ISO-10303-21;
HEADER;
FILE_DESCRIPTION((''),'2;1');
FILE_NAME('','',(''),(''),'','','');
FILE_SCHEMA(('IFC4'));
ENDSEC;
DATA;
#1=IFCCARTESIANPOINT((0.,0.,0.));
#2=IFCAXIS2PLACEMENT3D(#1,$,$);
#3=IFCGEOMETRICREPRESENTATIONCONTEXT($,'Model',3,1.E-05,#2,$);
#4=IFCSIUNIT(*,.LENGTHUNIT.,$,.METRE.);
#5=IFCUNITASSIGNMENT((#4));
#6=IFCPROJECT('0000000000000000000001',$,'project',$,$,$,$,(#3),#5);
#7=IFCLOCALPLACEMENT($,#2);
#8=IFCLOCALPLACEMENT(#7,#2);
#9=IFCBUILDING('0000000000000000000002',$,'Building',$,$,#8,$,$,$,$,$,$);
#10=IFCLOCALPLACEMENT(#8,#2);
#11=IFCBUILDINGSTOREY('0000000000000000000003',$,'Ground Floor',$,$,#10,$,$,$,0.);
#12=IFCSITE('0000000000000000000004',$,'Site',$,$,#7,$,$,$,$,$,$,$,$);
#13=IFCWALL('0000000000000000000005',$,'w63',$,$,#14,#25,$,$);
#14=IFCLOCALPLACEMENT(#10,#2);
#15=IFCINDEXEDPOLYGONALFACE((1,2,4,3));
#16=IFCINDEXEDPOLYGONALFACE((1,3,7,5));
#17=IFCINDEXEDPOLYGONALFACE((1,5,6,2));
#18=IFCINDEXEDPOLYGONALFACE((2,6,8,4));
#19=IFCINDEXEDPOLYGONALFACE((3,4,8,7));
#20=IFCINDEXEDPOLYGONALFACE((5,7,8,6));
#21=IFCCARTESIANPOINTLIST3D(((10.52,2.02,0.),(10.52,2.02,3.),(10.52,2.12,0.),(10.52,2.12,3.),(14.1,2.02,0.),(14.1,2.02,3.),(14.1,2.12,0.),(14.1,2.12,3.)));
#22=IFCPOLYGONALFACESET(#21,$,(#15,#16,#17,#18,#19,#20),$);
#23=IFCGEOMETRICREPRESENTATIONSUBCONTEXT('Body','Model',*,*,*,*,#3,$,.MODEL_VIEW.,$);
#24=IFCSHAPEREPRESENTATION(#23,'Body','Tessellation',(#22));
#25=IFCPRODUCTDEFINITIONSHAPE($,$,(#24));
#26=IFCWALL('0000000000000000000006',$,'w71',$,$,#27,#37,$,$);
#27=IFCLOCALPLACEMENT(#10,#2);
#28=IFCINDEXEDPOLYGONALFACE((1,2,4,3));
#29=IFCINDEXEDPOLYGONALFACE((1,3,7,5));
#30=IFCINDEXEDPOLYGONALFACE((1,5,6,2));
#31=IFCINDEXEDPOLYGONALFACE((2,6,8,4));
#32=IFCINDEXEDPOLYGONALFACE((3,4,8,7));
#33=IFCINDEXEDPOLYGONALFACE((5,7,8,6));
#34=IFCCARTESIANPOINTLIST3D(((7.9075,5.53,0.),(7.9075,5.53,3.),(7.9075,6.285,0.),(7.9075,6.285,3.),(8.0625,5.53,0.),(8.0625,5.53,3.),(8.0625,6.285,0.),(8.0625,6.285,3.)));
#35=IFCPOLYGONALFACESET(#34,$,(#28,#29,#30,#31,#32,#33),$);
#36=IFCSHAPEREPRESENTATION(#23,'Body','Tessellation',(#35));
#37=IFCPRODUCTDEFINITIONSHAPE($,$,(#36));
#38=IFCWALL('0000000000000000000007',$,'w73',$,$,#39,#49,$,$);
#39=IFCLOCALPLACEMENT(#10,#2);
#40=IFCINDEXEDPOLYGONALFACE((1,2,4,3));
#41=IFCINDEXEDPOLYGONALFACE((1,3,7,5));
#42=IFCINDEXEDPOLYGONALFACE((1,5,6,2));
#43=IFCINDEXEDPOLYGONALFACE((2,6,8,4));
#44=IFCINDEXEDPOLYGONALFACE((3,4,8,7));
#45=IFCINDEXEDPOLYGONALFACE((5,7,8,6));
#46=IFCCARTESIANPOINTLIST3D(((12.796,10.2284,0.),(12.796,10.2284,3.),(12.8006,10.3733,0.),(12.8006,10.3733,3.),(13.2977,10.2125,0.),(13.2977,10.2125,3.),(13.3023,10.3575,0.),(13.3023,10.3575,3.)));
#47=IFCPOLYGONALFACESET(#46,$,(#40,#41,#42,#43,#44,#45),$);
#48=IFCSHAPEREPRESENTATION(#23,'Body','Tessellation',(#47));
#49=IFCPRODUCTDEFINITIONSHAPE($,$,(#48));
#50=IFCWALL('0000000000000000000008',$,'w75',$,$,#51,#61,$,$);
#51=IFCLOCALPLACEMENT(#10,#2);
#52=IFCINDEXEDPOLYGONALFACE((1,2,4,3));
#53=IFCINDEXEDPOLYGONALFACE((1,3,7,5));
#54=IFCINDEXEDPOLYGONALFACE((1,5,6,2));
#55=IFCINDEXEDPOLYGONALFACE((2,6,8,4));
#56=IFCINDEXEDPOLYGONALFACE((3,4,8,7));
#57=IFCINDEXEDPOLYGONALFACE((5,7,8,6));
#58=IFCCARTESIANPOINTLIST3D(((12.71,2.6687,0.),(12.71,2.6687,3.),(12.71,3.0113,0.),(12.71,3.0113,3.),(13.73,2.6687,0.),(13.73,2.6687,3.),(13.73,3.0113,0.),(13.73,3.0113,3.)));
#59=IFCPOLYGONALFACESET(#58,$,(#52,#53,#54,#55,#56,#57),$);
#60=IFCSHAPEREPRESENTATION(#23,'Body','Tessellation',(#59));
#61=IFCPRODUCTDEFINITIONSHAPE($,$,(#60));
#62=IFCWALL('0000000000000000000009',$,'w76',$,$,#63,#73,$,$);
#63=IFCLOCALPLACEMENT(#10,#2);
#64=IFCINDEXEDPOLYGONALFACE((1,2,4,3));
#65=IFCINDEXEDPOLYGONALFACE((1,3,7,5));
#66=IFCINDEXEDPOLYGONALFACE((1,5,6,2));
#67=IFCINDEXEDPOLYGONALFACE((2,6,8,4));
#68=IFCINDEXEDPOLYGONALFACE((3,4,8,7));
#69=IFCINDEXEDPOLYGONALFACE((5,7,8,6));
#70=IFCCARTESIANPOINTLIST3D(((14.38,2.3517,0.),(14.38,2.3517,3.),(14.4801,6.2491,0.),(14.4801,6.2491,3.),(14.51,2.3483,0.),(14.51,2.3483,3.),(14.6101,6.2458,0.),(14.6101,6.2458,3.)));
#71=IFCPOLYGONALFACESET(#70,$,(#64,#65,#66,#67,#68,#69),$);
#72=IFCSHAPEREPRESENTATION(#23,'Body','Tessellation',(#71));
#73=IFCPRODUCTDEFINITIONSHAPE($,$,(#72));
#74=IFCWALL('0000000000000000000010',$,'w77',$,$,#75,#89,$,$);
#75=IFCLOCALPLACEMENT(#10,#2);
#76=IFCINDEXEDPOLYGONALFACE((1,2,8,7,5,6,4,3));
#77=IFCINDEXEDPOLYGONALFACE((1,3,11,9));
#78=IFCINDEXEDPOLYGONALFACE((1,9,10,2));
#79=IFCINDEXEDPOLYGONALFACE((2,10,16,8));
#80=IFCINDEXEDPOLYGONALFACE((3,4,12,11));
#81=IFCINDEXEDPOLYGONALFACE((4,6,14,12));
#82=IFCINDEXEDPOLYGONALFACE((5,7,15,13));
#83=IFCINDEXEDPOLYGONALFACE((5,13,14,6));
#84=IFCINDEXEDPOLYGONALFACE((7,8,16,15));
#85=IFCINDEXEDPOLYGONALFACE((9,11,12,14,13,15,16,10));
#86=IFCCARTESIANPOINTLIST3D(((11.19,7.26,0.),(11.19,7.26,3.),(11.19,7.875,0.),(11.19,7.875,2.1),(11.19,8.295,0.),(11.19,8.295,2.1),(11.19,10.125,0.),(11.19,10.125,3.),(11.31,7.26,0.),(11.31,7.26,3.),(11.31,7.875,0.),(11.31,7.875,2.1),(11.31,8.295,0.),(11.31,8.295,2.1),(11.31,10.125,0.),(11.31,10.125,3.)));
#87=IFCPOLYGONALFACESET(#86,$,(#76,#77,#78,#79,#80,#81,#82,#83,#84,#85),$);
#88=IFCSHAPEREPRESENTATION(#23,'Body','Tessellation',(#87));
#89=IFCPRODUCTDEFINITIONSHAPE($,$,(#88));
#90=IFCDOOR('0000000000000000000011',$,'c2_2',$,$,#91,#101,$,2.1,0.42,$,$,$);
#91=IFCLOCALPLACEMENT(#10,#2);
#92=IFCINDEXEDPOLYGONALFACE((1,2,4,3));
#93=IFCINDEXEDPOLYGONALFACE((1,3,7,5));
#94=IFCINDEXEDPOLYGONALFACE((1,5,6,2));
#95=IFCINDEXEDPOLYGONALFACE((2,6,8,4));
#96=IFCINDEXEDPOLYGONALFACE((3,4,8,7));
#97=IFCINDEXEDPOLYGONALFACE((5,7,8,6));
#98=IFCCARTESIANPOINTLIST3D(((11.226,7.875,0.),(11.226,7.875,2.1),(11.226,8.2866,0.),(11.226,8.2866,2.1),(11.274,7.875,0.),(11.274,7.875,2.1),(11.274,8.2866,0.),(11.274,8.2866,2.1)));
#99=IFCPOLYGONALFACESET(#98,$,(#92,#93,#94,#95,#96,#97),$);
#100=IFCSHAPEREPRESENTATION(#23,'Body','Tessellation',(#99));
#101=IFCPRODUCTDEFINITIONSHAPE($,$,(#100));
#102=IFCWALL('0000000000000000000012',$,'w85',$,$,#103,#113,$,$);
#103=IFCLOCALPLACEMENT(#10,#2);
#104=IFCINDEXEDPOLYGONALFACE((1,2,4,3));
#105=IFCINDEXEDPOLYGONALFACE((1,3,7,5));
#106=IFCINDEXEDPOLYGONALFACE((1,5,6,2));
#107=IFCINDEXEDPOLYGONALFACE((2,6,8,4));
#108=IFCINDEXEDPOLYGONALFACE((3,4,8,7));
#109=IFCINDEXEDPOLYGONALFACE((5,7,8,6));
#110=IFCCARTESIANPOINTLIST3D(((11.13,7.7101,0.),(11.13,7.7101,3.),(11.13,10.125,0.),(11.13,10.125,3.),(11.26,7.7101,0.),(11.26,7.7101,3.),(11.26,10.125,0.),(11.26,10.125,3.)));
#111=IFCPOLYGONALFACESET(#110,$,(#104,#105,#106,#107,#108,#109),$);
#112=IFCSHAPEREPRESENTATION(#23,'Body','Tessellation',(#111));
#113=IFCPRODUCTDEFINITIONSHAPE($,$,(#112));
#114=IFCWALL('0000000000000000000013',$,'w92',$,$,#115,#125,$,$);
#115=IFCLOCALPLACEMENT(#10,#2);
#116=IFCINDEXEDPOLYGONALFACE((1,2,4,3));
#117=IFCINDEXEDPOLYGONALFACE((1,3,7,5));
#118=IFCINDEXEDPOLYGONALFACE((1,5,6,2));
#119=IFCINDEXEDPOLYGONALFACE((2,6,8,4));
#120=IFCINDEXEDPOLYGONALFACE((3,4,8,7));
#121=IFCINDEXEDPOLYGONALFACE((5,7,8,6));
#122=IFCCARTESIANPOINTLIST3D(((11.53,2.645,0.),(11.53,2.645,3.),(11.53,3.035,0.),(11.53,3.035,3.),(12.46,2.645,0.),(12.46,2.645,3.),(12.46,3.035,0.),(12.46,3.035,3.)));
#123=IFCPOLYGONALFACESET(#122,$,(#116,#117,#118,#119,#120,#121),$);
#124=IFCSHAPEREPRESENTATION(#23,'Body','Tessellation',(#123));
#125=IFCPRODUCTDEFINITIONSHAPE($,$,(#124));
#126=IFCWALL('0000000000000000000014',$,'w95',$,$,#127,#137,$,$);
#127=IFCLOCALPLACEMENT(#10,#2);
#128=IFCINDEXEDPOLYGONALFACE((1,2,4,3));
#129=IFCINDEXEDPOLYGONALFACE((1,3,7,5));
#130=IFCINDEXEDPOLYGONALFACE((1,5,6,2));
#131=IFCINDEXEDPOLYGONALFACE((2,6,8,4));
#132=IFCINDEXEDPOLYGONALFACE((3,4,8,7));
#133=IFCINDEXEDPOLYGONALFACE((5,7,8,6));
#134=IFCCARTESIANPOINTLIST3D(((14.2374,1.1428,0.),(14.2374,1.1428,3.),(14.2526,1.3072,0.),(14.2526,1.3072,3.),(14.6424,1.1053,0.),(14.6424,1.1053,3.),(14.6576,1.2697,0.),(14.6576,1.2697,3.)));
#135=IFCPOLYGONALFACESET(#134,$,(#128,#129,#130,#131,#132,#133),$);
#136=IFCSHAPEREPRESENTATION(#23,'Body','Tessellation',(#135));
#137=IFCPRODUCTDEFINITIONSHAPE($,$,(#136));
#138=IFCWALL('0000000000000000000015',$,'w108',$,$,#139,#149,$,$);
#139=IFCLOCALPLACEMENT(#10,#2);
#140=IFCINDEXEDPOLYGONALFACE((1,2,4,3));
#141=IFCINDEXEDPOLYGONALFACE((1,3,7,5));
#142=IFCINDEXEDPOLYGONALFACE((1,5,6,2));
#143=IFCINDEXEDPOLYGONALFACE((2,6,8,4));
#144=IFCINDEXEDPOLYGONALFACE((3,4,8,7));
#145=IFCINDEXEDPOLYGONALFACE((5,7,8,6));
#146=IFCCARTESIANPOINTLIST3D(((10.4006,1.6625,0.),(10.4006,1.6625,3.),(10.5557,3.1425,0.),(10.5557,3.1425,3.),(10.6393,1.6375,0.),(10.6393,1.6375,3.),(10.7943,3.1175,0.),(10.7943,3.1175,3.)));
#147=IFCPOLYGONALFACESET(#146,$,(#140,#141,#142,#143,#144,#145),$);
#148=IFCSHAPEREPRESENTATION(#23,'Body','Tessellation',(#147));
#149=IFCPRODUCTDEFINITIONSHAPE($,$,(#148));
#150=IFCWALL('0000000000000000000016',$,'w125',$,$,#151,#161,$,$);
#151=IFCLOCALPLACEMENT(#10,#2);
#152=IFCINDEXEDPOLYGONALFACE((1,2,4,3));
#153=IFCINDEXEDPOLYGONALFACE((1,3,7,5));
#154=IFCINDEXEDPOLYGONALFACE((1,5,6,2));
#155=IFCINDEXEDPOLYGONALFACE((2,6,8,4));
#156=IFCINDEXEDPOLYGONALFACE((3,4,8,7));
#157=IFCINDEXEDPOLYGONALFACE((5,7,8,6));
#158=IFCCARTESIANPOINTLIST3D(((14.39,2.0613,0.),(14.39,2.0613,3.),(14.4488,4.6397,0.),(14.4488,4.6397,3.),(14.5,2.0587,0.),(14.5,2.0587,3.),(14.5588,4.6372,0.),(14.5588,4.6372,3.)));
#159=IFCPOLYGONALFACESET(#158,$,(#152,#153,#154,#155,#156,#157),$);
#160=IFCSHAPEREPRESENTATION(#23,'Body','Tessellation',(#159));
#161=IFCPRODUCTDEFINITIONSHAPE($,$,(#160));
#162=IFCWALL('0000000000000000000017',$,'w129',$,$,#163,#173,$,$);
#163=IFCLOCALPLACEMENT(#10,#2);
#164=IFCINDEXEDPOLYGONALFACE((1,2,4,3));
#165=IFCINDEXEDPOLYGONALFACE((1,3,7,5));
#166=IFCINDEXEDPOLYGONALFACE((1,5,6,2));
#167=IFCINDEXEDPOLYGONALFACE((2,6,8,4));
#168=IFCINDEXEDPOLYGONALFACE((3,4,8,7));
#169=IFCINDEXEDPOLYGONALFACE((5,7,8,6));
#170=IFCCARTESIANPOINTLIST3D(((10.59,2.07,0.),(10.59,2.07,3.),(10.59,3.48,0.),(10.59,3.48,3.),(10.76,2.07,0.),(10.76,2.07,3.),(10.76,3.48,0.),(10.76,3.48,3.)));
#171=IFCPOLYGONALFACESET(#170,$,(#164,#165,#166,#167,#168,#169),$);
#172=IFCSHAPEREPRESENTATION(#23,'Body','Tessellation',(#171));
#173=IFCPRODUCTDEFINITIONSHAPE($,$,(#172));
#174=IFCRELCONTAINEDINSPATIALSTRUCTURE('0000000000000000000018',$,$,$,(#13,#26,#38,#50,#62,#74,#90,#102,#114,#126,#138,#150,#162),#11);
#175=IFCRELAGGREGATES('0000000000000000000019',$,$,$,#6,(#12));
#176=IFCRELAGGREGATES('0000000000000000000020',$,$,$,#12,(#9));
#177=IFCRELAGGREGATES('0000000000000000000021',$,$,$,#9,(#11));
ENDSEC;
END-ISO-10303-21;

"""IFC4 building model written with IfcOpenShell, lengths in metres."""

from ifc_helpers import new_model, si_unit, frame, origin, place, context, subcontext, project, spatial, polyline, outline, extrude, element, fill, save


model = new_model("IFC4")

# Units and contexts
model_context = context("Model", 3, precision=1e-05, world=origin())
body_context = subcontext(model_context, "Body", "Model", "MODEL_VIEW")
ifc_project = project(units=[si_unit("LENGTHUNIT", "METRE")], contexts=[model_context])

# Site, building, storey
site_placement = place(None, origin())
site = spatial("IfcSite", under=ifc_project, at=site_placement, Name="Site")
building_placement = place(site_placement, origin())
building = spatial("IfcBuilding", under=site, at=building_placement, Name="Building")
storey_placement = place(building_placement, origin())
storey = spatial("IfcBuildingStorey", under=building, at=storey_placement, Name="Ground Floor", Elevation=0.0)

# Walls
wall_1_placement = place(storey_placement, frame((10.52, 2.07, 0.0), x_axis=(1.0, 0.0, 0.0)))
element("IfcWall", 1, at=wall_1_placement, inside=storey, Name="w63", context=body_context, shape_type="SweptSolid", body=[
    extrude(outline(polyline([(0.0, -0.05), (3.58, -0.05), (3.58, 0.05), (0.0, 0.05), (0.0, -0.05)])), origin(), (0.0, 0.0, 1.0), 3.0),
])
wall_2_placement = place(storey_placement, frame((7.985, 5.53, 0.0), x_axis=(0.0, 1.0, 0.0)))
element("IfcWall", 2, at=wall_2_placement, inside=storey, Name="w71", context=body_context, shape_type="SweptSolid", body=[
    extrude(outline(polyline([(0.0, -0.0775), (0.755, -0.0775), (0.755, 0.0775), (0.0, 0.0775), (0.0, -0.0775)])), origin(), (0.0, 0.0, 1.0), 3.0),
])
wall_3_placement = place(storey_placement, frame((12.7983, 10.3008, 0.0), x_axis=(0.999502, -0.031547, 0.0)))
element("IfcWall", 3, at=wall_3_placement, inside=storey, Name="w73", context=body_context, shape_type="SweptSolid", body=[
    extrude(outline(polyline([(0.0, -0.0725), (0.5019, -0.0725), (0.5019, 0.0725), (0.0, 0.0725), (0.0, -0.0725)])), origin(), (0.0, 0.0, 1.0), 3.0),
])
wall_4_placement = place(storey_placement, frame((12.71, 2.84, 0.0), x_axis=(1.0, 0.0, 0.0)))
element("IfcWall", 4, at=wall_4_placement, inside=storey, Name="w75", context=body_context, shape_type="SweptSolid", body=[
    extrude(outline(polyline([(0.0, -0.1713), (1.02, -0.1713), (1.02, 0.1713), (0.0, 0.1713), (0.0, -0.1713)])), origin(), (0.0, 0.0, 1.0), 3.0),
])
wall_5_placement = place(storey_placement, frame((14.445, 2.35, 0.0), x_axis=(0.025669, 0.99967, 0.0)))
element("IfcWall", 5, at=wall_5_placement, inside=storey, Name="w76", context=body_context, shape_type="SweptSolid", body=[
    extrude(outline(polyline([(0.0, -0.065), (3.8987, -0.065), (3.8987, 0.065), (0.0, 0.065), (0.0, -0.065)])), origin(), (0.0, 0.0, 1.0), 3.0),
])

# Wall, opening, door
wall_6_placement = place(storey_placement, frame((11.25, 7.26, 0.0), x_axis=(0.0, 1.0, 0.0)))
wall_6 = element("IfcWall", 6, at=wall_6_placement, inside=storey, Name="w77", context=body_context, shape_type="SweptSolid", body=[
    extrude(outline(polyline([(0.0, -0.06), (2.865, -0.06), (2.865, 0.06), (0.0, 0.06), (0.0, -0.06)])), origin(), (0.0, 0.0, 1.0), 3.0),
])
opening_1_placement = place(wall_6_placement, frame((0.615, 0.0, 0.0)))
opening_1 = element("IfcOpeningElement", 7, at=opening_1_placement, cuts=wall_6, context=body_context, shape_type="SweptSolid", body=[
    extrude(outline(polyline([(0.0, -0.063), (0.42, -0.063), (0.42, 0.063), (0.0, 0.063), (0.0, -0.063)])), origin(), (0.0, 0.0, 1.0), 2.1),
])
door_placement = place(wall_6_placement, frame((0.615, 0.0, 0.0)))
door = element("IfcDoor", 8, at=door_placement, inside=storey, Name="c2_2", OverallHeight=2.1, OverallWidth=0.42, context=body_context, shape_type="SweptSolid", body=[
    extrude(outline(polyline([(0.0, -0.024), (0.4116, -0.024), (0.4116, 0.024), (0.0, 0.024), (0.0, -0.024)])), origin(), (0.0, 0.0, 1.0), 2.1),
])
fill(opening_1, door)

# Walls
wall_7_placement = place(storey_placement, frame((11.195, 7.7101, 0.0), x_axis=(0.0, 1.0, 0.0)))
element("IfcWall", 9, at=wall_7_placement, inside=storey, Name="w85", context=body_context, shape_type="SweptSolid", body=[
    extrude(outline(polyline([(0.0, -0.065), (2.4149, -0.065), (2.4149, 0.065), (0.0, 0.065), (0.0, -0.065)])), origin(), (0.0, 0.0, 1.0), 3.0),
])
wall_8_placement = place(storey_placement, frame((11.53, 2.84, 0.0), x_axis=(1.0, 0.0, 0.0)))
element("IfcWall", 10, at=wall_8_placement, inside=storey, Name="w92", context=body_context, shape_type="SweptSolid", body=[
    extrude(outline(polyline([(0.0, -0.195), (0.93, -0.195), (0.93, 0.195), (0.0, 0.195), (0.0, -0.195)])), origin(), (0.0, 0.0, 1.0), 3.0),
])
wall_9_placement = place(storey_placement, frame((14.245, 1.225, 0.0), x_axis=(0.99574, -0.0922, 0.0)))
element("IfcWall", 11, at=wall_9_placement, inside=storey, Name="w95", context=body_context, shape_type="SweptSolid", body=[
    extrude(outline(polyline([(0.0, -0.0825), (0.4067, -0.0825), (0.4067, 0.0825), (0.0, 0.0825), (0.0, -0.0825)])), origin(), (0.0, 0.0, 1.0), 3.0),
])
wall_10_placement = place(storey_placement, frame((10.52, 1.65, 0.0), x_axis=(0.104164, 0.99456, 0.0)))
element("IfcWall", 12, at=wall_10_placement, inside=storey, Name="w108", context=body_context, shape_type="SweptSolid", body=[
    extrude(outline(polyline([(0.0, -0.12), (1.4881, -0.12), (1.4881, 0.12), (0.0, 0.12), (0.0, -0.12)])), origin(), (0.0, 0.0, 1.0), 3.0),
])
wall_11_placement = place(storey_placement, frame((14.445, 2.06, 0.0), x_axis=(0.022784, 0.99974, 0.0)))
element("IfcWall", 13, at=wall_11_placement, inside=storey, Name="w125", context=body_context, shape_type="SweptSolid", body=[
    extrude(outline(polyline([(0.0, -0.055), (2.5792, -0.055), (2.5792, 0.055), (0.0, 0.055), (0.0, -0.055)])), origin(), (0.0, 0.0, 1.0), 3.0),
])
wall_12_placement = place(storey_placement, frame((10.675, 2.07, 0.0), x_axis=(0.0, 1.0, 0.0)))
element("IfcWall", 14, at=wall_12_placement, inside=storey, Name="w129", context=body_context, shape_type="SweptSolid", body=[
    extrude(outline(polyline([(0.0, -0.085), (1.41, -0.085), (1.41, 0.085), (0.0, 0.085), (0.0, -0.085)])), origin(), (0.0, 0.0, 1.0), 3.0),
])

save(model, "model.ifc")
